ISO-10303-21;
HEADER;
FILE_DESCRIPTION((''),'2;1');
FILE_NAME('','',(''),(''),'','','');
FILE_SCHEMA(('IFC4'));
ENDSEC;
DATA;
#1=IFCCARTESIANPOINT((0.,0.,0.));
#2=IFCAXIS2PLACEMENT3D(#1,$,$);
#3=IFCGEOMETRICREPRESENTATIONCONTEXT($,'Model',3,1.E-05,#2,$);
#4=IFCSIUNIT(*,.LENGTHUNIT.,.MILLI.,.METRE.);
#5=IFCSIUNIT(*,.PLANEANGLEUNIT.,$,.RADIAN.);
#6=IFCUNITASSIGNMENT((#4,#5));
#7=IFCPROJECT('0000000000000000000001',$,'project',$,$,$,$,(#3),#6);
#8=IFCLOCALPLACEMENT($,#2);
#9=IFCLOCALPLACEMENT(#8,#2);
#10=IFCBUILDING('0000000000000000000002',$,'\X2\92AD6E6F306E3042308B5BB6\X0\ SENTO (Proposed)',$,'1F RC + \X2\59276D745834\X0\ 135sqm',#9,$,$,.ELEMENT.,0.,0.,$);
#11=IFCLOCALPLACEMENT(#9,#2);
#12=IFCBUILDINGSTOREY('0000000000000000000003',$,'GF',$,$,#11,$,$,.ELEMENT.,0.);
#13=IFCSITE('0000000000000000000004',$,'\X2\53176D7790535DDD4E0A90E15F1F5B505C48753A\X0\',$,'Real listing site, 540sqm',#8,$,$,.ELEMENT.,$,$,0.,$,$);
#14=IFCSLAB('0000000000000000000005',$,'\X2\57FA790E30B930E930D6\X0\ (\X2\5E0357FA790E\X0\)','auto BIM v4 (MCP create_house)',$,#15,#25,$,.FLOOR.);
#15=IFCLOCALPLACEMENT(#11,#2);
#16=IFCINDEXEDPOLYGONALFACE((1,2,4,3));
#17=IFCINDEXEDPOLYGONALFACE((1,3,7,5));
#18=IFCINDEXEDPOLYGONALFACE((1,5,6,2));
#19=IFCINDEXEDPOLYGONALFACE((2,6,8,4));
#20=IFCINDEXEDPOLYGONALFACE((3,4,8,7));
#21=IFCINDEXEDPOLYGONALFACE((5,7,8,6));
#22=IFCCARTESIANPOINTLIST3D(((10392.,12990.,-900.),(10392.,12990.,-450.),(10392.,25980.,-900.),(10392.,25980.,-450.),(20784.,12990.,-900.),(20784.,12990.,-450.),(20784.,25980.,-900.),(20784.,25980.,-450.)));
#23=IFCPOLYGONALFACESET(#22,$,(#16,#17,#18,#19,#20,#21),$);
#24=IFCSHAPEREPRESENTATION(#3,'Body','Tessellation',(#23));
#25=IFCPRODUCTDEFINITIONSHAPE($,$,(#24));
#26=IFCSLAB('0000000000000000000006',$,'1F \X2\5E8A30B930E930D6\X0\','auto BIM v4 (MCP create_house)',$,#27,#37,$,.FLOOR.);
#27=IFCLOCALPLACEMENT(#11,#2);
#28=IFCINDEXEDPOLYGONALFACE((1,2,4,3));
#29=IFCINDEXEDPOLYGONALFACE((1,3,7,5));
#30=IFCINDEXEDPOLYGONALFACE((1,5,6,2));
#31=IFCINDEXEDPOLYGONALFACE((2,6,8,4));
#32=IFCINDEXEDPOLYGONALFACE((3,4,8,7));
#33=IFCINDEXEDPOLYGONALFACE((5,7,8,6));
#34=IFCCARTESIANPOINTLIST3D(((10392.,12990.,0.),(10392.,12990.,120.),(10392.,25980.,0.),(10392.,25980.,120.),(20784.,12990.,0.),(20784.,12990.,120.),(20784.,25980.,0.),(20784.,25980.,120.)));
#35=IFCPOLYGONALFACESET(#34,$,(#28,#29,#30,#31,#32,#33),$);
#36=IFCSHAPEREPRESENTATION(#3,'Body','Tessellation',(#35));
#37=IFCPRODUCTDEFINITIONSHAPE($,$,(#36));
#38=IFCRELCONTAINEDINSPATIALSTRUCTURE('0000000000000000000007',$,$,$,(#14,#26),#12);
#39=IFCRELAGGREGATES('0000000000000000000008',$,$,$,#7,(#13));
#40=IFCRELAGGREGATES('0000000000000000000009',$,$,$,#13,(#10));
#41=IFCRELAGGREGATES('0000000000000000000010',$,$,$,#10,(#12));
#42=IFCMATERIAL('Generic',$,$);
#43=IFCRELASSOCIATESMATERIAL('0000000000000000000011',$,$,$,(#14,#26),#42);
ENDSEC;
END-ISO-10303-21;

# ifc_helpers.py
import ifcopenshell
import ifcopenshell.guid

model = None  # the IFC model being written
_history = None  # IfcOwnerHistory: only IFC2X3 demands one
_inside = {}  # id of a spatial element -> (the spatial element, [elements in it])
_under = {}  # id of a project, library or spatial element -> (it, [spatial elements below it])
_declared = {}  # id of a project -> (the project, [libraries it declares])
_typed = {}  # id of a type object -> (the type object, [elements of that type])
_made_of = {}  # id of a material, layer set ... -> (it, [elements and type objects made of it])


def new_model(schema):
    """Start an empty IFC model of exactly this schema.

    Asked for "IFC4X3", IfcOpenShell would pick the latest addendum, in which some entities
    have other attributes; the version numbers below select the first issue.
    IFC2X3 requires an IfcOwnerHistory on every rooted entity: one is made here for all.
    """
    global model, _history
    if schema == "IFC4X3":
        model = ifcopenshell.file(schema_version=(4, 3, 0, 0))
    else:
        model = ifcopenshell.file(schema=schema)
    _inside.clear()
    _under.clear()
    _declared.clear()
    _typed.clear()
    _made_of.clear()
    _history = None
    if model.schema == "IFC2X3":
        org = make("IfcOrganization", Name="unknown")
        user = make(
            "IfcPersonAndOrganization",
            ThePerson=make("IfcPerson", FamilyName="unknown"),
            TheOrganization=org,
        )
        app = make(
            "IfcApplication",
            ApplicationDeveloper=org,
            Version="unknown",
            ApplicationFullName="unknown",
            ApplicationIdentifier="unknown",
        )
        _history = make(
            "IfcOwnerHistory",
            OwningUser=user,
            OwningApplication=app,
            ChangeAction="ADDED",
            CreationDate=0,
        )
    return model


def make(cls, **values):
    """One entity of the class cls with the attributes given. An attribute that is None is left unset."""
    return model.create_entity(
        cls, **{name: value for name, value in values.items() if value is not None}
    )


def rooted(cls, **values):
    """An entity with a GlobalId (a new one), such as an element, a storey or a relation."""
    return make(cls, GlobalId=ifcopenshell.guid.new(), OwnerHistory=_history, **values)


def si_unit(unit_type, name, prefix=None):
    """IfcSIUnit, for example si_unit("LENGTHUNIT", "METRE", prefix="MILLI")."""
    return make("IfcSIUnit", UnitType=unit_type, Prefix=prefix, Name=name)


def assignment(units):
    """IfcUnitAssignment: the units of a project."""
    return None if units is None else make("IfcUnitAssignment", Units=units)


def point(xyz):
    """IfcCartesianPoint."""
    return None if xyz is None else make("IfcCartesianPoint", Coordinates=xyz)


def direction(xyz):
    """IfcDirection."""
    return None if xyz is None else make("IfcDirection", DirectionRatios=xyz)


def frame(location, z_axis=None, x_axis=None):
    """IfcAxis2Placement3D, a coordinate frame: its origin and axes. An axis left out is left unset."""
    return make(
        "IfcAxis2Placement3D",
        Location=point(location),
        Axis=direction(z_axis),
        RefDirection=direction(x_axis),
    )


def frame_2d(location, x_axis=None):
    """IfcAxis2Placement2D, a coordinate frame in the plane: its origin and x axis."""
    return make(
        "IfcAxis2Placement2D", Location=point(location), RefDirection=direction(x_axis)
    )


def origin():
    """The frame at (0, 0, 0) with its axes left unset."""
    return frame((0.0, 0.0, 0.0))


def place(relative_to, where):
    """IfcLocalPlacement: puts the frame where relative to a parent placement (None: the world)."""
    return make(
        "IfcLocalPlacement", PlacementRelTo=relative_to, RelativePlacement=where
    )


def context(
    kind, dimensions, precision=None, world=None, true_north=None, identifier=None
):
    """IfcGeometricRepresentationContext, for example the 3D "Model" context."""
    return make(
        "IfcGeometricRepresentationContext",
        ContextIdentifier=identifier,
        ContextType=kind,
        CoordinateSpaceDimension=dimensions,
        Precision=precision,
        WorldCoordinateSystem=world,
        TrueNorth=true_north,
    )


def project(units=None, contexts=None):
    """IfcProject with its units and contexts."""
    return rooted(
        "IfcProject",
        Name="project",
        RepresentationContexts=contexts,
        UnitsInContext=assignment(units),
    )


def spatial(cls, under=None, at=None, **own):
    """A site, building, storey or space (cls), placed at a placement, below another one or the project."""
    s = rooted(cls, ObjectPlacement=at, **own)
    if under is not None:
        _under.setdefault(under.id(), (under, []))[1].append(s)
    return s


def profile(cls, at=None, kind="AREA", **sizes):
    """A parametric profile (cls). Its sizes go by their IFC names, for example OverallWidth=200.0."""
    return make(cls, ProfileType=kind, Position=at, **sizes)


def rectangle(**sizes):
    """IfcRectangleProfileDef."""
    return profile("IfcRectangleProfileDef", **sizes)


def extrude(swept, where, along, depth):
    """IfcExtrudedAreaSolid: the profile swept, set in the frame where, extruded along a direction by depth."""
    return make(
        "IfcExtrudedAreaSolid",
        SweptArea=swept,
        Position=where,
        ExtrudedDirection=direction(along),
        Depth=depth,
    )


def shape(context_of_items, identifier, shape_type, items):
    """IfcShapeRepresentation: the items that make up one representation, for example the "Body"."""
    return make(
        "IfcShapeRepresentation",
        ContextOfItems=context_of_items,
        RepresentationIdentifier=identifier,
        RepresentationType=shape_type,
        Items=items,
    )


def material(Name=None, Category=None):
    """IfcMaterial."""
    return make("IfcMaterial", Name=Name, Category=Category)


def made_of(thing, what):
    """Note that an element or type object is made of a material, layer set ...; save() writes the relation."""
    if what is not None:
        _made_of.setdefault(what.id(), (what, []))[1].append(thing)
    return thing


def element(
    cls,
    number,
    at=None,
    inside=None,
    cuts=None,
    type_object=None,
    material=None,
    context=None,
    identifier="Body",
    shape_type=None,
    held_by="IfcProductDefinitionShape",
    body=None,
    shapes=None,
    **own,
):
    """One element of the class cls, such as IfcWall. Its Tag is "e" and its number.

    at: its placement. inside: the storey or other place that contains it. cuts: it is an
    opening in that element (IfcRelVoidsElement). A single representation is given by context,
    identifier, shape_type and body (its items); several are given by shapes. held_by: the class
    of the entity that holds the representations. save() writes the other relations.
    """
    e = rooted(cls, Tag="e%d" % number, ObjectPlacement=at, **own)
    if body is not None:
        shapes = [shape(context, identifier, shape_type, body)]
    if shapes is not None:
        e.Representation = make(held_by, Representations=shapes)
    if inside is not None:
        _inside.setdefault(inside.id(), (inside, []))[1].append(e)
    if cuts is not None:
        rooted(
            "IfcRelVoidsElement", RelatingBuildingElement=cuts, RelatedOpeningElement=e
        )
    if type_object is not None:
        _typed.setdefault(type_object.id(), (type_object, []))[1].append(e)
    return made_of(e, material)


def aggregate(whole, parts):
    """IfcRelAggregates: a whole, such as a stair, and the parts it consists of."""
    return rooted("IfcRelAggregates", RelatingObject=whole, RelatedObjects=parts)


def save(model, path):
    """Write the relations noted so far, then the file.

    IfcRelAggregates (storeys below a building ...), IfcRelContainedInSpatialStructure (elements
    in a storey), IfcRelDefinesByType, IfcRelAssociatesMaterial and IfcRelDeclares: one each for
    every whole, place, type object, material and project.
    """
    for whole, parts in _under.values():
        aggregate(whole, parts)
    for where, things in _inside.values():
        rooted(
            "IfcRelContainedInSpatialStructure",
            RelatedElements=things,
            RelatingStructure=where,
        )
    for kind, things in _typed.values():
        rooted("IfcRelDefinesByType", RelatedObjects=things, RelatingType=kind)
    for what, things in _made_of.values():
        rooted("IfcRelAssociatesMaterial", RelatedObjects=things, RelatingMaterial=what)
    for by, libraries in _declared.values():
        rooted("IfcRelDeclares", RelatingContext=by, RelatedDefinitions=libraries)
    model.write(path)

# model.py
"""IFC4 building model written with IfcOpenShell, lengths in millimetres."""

from ifc_helpers import new_model, si_unit, frame, frame_2d, origin, place, context, project, spatial, rectangle, extrude, material, element, save


model = new_model("IFC4")

# Units and contexts
model_context = context("Model", 3, precision=1e-05, world=origin())
ifc_project = project(units=[si_unit("LENGTHUNIT", "METRE", prefix="MILLI"), si_unit("PLANEANGLEUNIT", "RADIAN")], contexts=[model_context])

# Site, building, storey
site_placement = place(None, origin())
site = spatial("IfcSite", under=ifc_project, at=site_placement, Name="北海道川上郡弟子屈町", ObjectType="Real listing site, 540sqm", CompositionType="ELEMENT", RefElevation=0.0)
building_placement = place(site_placement, origin())
building = spatial("IfcBuilding", under=site, at=building_placement, Name="銭湯のある家 SENTO (Proposed)", ObjectType="1F RC + 大浴場 135sqm", CompositionType="ELEMENT", ElevationOfRefHeight=0.0, ElevationOfTerrain=0.0)
storey_placement = place(building_placement, origin())
storey = spatial("IfcBuildingStorey", under=building, at=storey_placement, Name="GF", CompositionType="ELEMENT", Elevation=0.0)

# Slabs
ifc_material = material(Name="Generic")
slab_1_placement = place(storey_placement, frame((5196.0, 6495.0, -450.0)))
element("IfcSlab", 1, at=slab_1_placement, inside=storey, material=ifc_material, Name="基礎スラブ (布基礎)", Description="auto BIM v4 (MCP create_house)", PredefinedType="FLOOR", context=model_context, shape_type="SweptSolid", body=[
    extrude(rectangle(XDim=10392.0, YDim=12990.0, at=frame_2d((5196.0, 6495.0))), frame((5196.0, 6495.0, -450.0)), (0.0, 0.0, 1.0), 450.0),
])
slab_2_placement = place(storey_placement, frame((5196.0, 6495.0, 0.0)))
element("IfcSlab", 2, at=slab_2_placement, inside=storey, material=ifc_material, Name="1F 床スラブ", Description="auto BIM v4 (MCP create_house)", PredefinedType="FLOOR", context=model_context, shape_type="SweptSolid", body=[
    extrude(rectangle(XDim=10392.0, YDim=12990.0, at=frame_2d((5196.0, 6495.0))), frame((5196.0, 6495.0, 0.0)), (0.0, 0.0, 1.0), 120.0),
])

save(model, "model.ifc")
